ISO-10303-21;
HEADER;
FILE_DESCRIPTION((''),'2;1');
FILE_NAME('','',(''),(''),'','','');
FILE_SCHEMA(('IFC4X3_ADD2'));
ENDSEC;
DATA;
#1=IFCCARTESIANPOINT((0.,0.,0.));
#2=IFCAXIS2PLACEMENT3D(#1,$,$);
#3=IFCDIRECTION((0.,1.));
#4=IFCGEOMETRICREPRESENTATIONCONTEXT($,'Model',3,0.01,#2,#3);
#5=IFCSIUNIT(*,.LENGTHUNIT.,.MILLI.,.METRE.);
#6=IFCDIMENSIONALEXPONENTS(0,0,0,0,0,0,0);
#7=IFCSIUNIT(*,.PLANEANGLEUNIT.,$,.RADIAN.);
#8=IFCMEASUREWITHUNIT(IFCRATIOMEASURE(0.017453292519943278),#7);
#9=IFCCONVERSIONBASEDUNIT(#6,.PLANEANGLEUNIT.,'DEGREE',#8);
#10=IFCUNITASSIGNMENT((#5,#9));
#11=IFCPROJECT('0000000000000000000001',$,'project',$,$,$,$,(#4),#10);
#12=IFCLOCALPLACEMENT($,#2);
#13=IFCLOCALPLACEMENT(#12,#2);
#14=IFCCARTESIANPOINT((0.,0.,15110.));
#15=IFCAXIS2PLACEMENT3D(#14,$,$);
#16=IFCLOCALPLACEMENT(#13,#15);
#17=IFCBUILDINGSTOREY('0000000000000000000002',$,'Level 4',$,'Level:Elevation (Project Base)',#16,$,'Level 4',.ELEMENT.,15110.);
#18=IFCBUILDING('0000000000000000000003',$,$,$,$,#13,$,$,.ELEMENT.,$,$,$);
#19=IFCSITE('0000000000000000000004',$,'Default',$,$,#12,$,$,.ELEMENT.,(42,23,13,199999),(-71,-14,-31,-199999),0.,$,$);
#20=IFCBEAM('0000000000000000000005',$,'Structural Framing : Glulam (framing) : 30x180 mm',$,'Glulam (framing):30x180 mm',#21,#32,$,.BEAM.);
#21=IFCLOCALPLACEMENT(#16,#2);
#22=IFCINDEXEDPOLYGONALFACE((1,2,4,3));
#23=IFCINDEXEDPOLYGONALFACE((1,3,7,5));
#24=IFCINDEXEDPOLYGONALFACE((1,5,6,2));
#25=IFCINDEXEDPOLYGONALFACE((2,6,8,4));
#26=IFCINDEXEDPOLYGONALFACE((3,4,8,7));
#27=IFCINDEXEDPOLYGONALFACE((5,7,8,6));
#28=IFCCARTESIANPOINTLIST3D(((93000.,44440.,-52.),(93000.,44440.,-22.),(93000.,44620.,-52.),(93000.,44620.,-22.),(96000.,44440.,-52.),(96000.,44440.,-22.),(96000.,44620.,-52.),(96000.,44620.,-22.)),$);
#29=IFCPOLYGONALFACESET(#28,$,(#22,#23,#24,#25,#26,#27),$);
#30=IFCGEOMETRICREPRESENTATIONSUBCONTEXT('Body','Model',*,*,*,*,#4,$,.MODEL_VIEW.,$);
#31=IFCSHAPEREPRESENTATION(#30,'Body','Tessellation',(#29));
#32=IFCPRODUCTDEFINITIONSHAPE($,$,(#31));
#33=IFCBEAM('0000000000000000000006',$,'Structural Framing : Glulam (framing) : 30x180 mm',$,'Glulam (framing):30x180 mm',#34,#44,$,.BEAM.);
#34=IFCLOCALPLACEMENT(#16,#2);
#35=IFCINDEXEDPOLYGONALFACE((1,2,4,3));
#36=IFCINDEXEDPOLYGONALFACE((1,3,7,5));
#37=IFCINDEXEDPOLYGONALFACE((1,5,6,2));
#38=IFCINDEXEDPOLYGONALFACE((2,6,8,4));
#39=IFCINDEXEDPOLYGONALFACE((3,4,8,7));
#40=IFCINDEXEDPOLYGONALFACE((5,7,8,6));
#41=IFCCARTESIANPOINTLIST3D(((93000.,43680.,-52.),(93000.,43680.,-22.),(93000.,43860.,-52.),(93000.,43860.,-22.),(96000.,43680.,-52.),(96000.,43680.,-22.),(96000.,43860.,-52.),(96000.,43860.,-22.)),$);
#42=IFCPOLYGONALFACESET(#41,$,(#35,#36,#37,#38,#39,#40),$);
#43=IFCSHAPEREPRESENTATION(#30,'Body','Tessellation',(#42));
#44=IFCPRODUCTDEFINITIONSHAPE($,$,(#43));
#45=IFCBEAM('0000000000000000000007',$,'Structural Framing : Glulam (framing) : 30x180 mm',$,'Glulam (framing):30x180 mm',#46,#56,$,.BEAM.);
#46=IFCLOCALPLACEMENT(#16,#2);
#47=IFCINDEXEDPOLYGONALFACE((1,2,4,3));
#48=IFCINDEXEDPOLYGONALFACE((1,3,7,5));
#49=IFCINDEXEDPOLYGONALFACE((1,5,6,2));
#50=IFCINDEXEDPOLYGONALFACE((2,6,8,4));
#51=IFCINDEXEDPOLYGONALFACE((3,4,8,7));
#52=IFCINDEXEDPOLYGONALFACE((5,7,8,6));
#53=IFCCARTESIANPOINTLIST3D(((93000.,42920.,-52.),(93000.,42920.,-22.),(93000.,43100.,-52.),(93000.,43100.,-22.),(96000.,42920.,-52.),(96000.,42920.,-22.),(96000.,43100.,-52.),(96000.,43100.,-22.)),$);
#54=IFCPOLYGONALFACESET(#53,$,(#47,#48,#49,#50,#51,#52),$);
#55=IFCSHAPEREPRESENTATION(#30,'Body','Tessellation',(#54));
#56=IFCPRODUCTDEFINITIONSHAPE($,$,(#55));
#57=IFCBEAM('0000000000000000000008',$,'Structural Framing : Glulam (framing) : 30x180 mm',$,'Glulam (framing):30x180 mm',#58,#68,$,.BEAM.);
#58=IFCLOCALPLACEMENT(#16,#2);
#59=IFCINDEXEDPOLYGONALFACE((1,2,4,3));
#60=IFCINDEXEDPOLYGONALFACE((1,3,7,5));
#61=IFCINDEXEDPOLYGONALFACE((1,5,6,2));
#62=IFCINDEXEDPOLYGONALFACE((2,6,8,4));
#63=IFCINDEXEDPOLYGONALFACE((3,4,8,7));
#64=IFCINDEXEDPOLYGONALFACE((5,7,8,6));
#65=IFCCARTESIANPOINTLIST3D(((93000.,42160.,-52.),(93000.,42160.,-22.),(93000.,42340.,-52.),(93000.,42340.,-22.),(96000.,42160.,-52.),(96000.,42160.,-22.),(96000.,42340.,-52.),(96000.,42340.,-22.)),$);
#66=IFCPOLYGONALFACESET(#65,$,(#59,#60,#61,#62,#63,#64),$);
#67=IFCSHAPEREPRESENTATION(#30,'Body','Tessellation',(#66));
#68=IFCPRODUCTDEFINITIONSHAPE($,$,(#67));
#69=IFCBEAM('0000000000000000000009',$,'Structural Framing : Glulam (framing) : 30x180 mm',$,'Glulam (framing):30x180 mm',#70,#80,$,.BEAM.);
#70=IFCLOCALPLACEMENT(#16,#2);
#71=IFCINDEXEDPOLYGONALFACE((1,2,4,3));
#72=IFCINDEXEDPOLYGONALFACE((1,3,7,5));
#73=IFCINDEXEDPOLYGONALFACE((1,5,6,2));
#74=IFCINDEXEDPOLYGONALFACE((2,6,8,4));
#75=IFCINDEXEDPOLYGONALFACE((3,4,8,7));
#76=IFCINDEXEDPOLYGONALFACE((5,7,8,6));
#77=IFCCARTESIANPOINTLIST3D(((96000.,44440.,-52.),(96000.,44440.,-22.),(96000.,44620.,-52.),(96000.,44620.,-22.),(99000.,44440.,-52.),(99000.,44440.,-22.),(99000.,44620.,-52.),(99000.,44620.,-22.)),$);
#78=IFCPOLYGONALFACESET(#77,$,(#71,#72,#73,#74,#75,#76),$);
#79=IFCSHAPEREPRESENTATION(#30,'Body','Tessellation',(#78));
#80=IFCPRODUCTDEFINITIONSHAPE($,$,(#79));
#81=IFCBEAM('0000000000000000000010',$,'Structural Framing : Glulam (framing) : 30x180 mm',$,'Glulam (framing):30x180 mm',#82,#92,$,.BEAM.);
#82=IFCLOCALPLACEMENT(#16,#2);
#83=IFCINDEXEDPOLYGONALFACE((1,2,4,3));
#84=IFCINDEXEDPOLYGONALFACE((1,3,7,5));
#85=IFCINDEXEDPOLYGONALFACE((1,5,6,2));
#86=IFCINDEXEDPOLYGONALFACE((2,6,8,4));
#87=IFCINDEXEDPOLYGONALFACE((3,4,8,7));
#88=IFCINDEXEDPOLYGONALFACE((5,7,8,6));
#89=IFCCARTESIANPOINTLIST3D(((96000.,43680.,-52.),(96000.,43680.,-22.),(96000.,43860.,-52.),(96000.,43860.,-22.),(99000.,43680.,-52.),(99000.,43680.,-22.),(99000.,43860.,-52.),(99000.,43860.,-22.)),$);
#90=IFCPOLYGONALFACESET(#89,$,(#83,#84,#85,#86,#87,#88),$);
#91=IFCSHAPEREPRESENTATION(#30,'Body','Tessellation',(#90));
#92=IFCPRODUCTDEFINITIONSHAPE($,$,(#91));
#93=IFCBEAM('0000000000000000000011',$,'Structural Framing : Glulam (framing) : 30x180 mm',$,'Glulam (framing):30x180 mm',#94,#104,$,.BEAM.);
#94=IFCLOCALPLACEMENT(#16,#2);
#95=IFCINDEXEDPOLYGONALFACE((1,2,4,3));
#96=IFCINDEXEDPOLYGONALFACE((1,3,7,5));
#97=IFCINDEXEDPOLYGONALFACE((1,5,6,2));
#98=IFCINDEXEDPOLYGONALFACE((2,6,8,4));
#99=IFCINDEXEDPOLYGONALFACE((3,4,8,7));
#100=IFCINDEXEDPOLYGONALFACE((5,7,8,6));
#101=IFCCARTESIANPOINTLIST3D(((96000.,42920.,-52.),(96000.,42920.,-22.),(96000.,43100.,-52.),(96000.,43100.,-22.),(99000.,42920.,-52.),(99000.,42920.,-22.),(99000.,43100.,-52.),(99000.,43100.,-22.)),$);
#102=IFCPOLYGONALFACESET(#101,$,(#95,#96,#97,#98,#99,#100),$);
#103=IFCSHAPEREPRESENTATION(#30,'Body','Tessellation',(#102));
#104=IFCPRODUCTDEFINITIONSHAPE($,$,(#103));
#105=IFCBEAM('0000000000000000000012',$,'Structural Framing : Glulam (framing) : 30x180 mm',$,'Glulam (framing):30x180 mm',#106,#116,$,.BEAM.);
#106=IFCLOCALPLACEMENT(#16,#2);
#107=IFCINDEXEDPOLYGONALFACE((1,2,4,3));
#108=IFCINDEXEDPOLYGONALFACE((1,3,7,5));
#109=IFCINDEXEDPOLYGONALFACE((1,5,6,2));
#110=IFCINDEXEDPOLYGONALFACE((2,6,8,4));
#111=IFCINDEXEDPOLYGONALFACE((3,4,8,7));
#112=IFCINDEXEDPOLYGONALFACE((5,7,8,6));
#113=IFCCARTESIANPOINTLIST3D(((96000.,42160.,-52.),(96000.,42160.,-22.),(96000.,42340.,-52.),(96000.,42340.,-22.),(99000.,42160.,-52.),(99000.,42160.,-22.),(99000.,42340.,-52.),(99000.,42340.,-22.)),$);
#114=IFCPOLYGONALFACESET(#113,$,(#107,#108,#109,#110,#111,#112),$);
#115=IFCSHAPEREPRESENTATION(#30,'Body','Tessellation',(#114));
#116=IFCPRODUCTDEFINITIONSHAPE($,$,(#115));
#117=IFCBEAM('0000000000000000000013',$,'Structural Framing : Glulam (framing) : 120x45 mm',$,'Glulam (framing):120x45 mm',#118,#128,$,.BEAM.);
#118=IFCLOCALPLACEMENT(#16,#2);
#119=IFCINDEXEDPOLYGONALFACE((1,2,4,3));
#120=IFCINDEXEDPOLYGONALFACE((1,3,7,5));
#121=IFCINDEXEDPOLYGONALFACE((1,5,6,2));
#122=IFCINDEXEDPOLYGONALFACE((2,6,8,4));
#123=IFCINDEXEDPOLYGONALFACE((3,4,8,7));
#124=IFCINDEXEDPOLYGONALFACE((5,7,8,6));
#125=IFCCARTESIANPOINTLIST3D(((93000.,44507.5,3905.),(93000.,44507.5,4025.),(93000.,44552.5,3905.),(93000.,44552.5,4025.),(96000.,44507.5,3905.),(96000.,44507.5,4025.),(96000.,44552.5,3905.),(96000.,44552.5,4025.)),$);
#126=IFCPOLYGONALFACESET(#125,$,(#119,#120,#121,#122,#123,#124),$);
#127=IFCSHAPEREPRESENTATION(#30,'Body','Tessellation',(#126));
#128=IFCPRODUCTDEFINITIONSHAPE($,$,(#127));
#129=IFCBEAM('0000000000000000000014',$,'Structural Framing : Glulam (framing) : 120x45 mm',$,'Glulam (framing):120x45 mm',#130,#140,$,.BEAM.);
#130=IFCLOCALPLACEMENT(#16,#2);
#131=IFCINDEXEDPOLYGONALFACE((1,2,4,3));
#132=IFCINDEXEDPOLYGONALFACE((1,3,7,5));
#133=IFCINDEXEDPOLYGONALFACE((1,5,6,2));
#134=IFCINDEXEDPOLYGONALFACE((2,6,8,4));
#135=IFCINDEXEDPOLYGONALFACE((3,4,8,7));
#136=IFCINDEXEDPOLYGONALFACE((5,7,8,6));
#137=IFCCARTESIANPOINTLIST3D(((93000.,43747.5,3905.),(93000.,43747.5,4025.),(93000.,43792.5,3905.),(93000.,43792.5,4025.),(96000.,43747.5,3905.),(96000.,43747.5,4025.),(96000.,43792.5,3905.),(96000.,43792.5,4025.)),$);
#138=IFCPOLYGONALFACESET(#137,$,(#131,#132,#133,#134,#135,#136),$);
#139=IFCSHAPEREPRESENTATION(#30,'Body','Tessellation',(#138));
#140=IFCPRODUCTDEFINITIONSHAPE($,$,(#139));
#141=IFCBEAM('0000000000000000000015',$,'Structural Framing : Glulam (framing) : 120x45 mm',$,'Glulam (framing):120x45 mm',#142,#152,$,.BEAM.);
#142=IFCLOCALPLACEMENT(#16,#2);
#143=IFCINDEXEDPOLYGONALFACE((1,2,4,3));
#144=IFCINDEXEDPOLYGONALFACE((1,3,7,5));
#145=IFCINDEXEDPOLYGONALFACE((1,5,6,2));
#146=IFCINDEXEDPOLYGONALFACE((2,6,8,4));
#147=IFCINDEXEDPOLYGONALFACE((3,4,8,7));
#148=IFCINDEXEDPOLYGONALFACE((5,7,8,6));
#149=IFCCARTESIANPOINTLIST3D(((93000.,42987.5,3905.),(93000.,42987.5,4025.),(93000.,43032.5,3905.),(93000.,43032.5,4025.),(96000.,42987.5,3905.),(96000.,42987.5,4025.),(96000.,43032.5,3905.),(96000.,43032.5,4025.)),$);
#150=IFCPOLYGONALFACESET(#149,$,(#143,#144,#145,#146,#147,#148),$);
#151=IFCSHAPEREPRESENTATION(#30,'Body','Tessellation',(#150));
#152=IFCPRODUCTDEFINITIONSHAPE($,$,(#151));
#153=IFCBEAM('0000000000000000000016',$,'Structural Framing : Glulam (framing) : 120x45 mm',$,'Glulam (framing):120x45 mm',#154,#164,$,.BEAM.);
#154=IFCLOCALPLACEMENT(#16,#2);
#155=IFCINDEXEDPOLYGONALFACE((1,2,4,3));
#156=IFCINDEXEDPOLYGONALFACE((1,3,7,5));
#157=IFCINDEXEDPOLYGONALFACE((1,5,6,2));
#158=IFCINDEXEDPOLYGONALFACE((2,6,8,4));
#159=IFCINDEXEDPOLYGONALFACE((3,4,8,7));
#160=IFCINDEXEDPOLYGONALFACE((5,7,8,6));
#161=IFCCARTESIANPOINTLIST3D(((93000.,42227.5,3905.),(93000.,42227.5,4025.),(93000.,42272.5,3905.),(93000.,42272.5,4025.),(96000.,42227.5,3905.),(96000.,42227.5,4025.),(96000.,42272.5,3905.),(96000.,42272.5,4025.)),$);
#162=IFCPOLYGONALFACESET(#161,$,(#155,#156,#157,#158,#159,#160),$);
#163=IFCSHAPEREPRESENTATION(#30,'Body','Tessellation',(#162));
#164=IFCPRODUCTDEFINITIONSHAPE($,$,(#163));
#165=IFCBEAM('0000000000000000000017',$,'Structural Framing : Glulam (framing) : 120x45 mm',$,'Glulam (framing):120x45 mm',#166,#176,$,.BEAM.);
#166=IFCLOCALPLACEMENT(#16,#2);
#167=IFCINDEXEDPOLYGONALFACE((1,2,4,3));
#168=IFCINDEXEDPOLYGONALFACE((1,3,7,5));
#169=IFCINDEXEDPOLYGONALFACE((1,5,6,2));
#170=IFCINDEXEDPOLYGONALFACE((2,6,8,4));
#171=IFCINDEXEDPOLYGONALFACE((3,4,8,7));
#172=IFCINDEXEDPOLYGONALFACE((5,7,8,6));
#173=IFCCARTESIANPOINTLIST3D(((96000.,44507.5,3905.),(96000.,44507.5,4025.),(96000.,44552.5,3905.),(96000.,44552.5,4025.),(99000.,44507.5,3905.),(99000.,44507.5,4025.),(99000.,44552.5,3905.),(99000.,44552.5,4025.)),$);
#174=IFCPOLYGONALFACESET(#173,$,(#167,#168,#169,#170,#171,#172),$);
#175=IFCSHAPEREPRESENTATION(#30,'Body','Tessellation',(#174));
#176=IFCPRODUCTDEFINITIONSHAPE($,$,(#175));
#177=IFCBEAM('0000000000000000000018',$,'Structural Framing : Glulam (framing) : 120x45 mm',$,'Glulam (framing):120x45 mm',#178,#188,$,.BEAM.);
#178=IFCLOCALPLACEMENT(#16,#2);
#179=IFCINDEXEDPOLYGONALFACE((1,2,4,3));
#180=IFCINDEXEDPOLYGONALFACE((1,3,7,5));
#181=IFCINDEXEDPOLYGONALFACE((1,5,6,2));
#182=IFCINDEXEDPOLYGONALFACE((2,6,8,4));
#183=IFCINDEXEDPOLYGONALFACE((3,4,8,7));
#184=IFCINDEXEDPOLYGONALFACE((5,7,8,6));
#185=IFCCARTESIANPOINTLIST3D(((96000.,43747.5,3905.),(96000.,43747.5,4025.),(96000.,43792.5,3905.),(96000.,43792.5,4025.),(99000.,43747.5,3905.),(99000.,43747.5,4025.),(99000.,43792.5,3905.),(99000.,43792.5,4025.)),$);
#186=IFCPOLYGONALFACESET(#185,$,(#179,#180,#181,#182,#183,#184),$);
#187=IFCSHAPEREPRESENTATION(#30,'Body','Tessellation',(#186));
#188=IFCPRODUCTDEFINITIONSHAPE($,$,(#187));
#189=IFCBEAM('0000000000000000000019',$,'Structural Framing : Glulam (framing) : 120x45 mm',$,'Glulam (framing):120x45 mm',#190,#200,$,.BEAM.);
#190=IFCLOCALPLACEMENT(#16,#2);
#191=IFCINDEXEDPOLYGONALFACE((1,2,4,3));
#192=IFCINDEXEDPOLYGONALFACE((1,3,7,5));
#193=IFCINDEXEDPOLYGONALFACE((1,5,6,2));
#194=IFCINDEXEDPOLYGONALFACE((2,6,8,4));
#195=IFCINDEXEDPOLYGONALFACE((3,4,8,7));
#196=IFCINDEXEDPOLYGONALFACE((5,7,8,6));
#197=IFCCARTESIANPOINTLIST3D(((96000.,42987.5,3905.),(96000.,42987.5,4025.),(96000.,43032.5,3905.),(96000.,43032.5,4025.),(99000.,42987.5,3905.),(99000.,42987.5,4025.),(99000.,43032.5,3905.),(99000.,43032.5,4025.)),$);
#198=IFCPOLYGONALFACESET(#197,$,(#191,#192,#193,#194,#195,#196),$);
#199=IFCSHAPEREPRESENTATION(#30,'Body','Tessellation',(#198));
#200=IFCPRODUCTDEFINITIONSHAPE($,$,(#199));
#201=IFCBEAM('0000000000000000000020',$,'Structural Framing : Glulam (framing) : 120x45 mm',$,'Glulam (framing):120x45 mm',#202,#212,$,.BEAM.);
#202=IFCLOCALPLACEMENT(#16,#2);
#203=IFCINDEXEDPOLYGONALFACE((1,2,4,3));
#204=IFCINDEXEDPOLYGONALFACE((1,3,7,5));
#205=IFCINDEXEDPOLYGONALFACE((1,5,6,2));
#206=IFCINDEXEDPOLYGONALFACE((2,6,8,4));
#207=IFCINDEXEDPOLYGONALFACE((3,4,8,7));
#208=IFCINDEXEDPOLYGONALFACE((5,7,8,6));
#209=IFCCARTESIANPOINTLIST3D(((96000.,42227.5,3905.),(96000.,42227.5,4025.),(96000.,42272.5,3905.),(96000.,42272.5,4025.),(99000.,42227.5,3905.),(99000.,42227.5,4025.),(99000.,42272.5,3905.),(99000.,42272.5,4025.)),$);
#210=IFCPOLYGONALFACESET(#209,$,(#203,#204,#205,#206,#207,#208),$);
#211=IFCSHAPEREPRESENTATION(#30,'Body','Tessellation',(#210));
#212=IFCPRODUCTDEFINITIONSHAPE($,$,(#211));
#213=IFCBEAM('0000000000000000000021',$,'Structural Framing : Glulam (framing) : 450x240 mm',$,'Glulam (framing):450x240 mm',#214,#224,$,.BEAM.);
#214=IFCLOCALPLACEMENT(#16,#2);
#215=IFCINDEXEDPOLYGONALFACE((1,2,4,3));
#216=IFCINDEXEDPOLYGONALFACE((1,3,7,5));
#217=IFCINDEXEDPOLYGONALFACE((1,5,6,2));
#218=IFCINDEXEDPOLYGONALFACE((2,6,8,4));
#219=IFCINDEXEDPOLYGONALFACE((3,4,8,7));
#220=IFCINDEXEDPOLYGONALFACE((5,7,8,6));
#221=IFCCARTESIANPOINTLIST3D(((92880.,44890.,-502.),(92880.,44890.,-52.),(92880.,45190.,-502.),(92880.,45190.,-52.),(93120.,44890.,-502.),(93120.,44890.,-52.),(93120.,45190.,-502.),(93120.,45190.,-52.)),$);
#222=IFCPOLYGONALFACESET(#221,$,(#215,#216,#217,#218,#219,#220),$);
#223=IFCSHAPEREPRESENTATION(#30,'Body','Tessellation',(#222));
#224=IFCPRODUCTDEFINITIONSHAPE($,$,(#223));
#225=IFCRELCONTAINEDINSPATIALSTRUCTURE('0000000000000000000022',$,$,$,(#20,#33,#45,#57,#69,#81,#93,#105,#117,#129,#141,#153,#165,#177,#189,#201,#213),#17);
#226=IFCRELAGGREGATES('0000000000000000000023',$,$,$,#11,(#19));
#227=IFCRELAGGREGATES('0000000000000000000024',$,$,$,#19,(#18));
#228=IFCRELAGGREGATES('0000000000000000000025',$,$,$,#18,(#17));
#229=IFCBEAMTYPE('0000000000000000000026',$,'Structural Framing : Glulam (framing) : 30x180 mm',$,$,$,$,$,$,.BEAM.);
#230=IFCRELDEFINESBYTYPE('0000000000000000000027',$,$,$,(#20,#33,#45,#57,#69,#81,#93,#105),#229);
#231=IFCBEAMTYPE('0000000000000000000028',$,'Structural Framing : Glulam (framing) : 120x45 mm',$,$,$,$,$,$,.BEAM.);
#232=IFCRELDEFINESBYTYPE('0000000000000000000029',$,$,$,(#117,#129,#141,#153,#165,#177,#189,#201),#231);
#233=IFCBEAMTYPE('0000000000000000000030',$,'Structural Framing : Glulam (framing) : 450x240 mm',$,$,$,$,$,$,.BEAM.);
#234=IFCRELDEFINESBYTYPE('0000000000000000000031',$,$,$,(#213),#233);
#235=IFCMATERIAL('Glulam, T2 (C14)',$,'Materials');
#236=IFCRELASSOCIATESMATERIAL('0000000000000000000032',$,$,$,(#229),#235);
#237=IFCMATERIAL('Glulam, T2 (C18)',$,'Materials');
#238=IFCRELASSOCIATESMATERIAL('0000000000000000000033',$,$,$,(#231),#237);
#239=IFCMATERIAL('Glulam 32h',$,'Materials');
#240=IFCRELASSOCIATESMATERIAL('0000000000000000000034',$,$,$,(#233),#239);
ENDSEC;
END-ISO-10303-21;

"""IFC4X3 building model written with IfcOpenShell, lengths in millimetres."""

from ifc_helpers import new_model, entity, si_unit, converted_unit, direction, frame, origin, origin_2d_with_axis, place, context, subcontext, project, spatial, rectangle, extrude, source, transform, mapped, material, material_profile, profile_set, type_object, type_shapes, element, save


model = new_model("IFC4X3")

# Units and contexts
model_context = context("Model", 3, precision=0.01, world=origin(), true_north=direction((0.0, 1.0)))
body_context = subcontext(model_context, "Body", "Model", "MODEL_VIEW")
ifc_project = project(units=[si_unit("LENGTHUNIT", "METRE", prefix="MILLI"), converted_unit("PLANEANGLEUNIT", "DEGREE", entity("IfcRatioMeasure", 0.017453292519943278), si_unit("PLANEANGLEUNIT", "RADIAN"), dimensions=[0, 0, 0, 0, 0, 0, 0])], contexts=[model_context])

# Site, building, storey
site_placement = place(None, origin())
site = spatial("IfcSite", under=ifc_project, at=site_placement, Name="Default", CompositionType="ELEMENT", RefLatitude=(42, 23, 13, 199999), RefLongitude=(-71, -14, -31, -199999), RefElevation=0.0)
building_placement = place(site_placement, origin())
building = spatial("IfcBuilding", under=site, at=building_placement, CompositionType="ELEMENT")
storey_placement = place(building_placement, frame((0.0, 0.0, 15110.0)))
storey = spatial("IfcBuildingStorey", under=building, at=storey_placement, Name="Level 4", ObjectType="Level:Elevation (Project Base)", LongName="Level 4", CompositionType="ELEMENT", Elevation=15110.0)

# Beams
ifc_material_1 = material(Name="Glulam, T2 (C14)", Category="Materials")
ifc_material_profile_1 = material_profile(ifc_material_1, rectangle(XDim=30.0, YDim=180.0, at=origin_2d_with_axis()), Name="30x180 mm")
ifc_profile_set_1 = profile_set([ifc_material_profile_1], Name="30x180 mm")
beam_type_1 = type_object("IfcBeamType", Name="Structural Framing : Glulam (framing) : 30x180 mm", PredefinedType="BEAM", material=ifc_profile_set_1)
shared_shape_1 = source(origin(), body_context, "Body", "SweptSolid", [
    extrude(rectangle(XDim=30.0, YDim=180.0, at=origin_2d_with_axis()), frame((500.0, 0.0, 0.0), z_axis=(1.0, 0.0, 0.0), x_axis=(0.0, 0.0, -1.0)), (0.0, 0.0, 1.0), 3000.0),
])
type_shapes(beam_type_1, [shared_shape_1])
for number, where, name in (
    (1, (92500.0, 44530.0, -37.0), "Structural Framing : Glulam (framing) : 30x180 mm"),
    (2, (92500.0, 43770.0, -37.0), "Structural Framing : Glulam (framing) : 30x180 mm"),
    (3, (92500.0, 43010.0, -37.0), "Structural Framing : Glulam (framing) : 30x180 mm"),
    (4, (92500.0, 42250.0, -37.0), "Structural Framing : Glulam (framing) : 30x180 mm"),
    (5, (95500.0, 44530.0, -37.0), "Structural Framing : Glulam (framing) : 30x180 mm"),
    (6, (95500.0, 43770.0, -37.0), "Structural Framing : Glulam (framing) : 30x180 mm"),
    (7, (95500.0, 43010.0, -37.0), "Structural Framing : Glulam (framing) : 30x180 mm"),
    (8, (95500.0, 42250.0, -37.0), "Structural Framing : Glulam (framing) : 30x180 mm"),
):
    element("IfcBeam", number, at=place(storey_placement, frame(where)), inside=storey, type_object=beam_type_1, Name=name, ObjectType="Glulam (framing):30x180 mm", PredefinedType="BEAM", context=body_context, shape_type="MappedRepresentation", body=[
        mapped(shared_shape_1, transform((0.0, 0.0, 0.0), scale=1.0)),
    ])
ifc_material_2 = material(Name="Glulam, T2 (C18)", Category="Materials")
ifc_material_profile_2 = material_profile(ifc_material_2, rectangle(XDim=120.0, YDim=45.0, at=origin_2d_with_axis()), Name="120x45 mm")
ifc_profile_set_2 = profile_set([ifc_material_profile_2], Name="120x45 mm")
beam_type_2 = type_object("IfcBeamType", Name="Structural Framing : Glulam (framing) : 120x45 mm", PredefinedType="BEAM", material=ifc_profile_set_2)
shared_shape_2 = source(origin(), body_context, "Body", "SweptSolid", [
    extrude(rectangle(XDim=120.0, YDim=45.0, at=origin_2d_with_axis()), frame((500.0, 0.0, 0.0), z_axis=(1.0, 0.0, 0.0), x_axis=(0.0, 0.0, -1.0)), (0.0, 0.0, 1.0), 3000.0),
])
type_shapes(beam_type_2, [shared_shape_2])
for number, where, name in (
    (9, (92500.0, 44530.0, 3965.0), "Structural Framing : Glulam (framing) : 120x45 mm"),
    (10, (92500.0, 43770.0, 3965.0), "Structural Framing : Glulam (framing) : 120x45 mm"),
    (11, (92500.0, 43010.0, 3965.0), "Structural Framing : Glulam (framing) : 120x45 mm"),
    (12, (92500.0, 42250.0, 3965.0), "Structural Framing : Glulam (framing) : 120x45 mm"),
    (13, (95500.0, 44530.0, 3965.0), "Structural Framing : Glulam (framing) : 120x45 mm"),
    (14, (95500.0, 43770.0, 3965.0), "Structural Framing : Glulam (framing) : 120x45 mm"),
    (15, (95500.0, 43010.0, 3965.0), "Structural Framing : Glulam (framing) : 120x45 mm"),
    (16, (95500.0, 42250.0, 3965.0), "Structural Framing : Glulam (framing) : 120x45 mm"),
):
    element("IfcBeam", number, at=place(storey_placement, frame(where)), inside=storey, type_object=beam_type_2, Name=name, ObjectType="Glulam (framing):120x45 mm", PredefinedType="BEAM", context=body_context, shape_type="MappedRepresentation", body=[
        mapped(shared_shape_2, transform((0.0, 0.0, 0.0), scale=1.0)),
    ])
ifc_material_3 = material(Name="Glulam 32h", Category="Materials")
ifc_material_profile_3 = material_profile(ifc_material_3, rectangle(XDim=450.0, YDim=240.0, at=origin_2d_with_axis()), Name="450x240 mm")
ifc_profile_set_3 = profile_set([ifc_material_profile_3], Name="450x240 mm")
beam_type_3 = type_object("IfcBeamType", Name="Structural Framing : Glulam (framing) : 450x240 mm", PredefinedType="BEAM", material=ifc_profile_set_3)
shared_shape_3 = source(origin(), body_context, "Body", "SweptSolid", [
    extrude(rectangle(XDim=450.0, YDim=240.0, at=origin_2d_with_axis()), frame((-1110.0, 0.0, 0.0), z_axis=(1.0, 0.0, 0.0), x_axis=(0.0, 0.0, -1.0)), (0.0, 0.0, 1.0), 300.0),
])
type_shapes(beam_type_3, [shared_shape_3])
for number, where, z_axis, x_axis, name in (
    (17, (93000.0, 44080.0, -277.0), (0.0, 0.0, 1.0), (0.0, -1.0, 0.0), "Structural Framing : Glulam (framing) : 450x240 mm"),
):
    element("IfcBeam", number, at=place(storey_placement, frame(where, z_axis=z_axis, x_axis=x_axis)), inside=storey, type_object=beam_type_3, Name=name, ObjectType="Glulam (framing):450x240 mm", PredefinedType="BEAM", context=body_context, shape_type="MappedRepresentation", body=[
        mapped(shared_shape_3, transform((0.0, 0.0, 0.0), scale=1.0)),
    ])

save(model, "model.ifc")
